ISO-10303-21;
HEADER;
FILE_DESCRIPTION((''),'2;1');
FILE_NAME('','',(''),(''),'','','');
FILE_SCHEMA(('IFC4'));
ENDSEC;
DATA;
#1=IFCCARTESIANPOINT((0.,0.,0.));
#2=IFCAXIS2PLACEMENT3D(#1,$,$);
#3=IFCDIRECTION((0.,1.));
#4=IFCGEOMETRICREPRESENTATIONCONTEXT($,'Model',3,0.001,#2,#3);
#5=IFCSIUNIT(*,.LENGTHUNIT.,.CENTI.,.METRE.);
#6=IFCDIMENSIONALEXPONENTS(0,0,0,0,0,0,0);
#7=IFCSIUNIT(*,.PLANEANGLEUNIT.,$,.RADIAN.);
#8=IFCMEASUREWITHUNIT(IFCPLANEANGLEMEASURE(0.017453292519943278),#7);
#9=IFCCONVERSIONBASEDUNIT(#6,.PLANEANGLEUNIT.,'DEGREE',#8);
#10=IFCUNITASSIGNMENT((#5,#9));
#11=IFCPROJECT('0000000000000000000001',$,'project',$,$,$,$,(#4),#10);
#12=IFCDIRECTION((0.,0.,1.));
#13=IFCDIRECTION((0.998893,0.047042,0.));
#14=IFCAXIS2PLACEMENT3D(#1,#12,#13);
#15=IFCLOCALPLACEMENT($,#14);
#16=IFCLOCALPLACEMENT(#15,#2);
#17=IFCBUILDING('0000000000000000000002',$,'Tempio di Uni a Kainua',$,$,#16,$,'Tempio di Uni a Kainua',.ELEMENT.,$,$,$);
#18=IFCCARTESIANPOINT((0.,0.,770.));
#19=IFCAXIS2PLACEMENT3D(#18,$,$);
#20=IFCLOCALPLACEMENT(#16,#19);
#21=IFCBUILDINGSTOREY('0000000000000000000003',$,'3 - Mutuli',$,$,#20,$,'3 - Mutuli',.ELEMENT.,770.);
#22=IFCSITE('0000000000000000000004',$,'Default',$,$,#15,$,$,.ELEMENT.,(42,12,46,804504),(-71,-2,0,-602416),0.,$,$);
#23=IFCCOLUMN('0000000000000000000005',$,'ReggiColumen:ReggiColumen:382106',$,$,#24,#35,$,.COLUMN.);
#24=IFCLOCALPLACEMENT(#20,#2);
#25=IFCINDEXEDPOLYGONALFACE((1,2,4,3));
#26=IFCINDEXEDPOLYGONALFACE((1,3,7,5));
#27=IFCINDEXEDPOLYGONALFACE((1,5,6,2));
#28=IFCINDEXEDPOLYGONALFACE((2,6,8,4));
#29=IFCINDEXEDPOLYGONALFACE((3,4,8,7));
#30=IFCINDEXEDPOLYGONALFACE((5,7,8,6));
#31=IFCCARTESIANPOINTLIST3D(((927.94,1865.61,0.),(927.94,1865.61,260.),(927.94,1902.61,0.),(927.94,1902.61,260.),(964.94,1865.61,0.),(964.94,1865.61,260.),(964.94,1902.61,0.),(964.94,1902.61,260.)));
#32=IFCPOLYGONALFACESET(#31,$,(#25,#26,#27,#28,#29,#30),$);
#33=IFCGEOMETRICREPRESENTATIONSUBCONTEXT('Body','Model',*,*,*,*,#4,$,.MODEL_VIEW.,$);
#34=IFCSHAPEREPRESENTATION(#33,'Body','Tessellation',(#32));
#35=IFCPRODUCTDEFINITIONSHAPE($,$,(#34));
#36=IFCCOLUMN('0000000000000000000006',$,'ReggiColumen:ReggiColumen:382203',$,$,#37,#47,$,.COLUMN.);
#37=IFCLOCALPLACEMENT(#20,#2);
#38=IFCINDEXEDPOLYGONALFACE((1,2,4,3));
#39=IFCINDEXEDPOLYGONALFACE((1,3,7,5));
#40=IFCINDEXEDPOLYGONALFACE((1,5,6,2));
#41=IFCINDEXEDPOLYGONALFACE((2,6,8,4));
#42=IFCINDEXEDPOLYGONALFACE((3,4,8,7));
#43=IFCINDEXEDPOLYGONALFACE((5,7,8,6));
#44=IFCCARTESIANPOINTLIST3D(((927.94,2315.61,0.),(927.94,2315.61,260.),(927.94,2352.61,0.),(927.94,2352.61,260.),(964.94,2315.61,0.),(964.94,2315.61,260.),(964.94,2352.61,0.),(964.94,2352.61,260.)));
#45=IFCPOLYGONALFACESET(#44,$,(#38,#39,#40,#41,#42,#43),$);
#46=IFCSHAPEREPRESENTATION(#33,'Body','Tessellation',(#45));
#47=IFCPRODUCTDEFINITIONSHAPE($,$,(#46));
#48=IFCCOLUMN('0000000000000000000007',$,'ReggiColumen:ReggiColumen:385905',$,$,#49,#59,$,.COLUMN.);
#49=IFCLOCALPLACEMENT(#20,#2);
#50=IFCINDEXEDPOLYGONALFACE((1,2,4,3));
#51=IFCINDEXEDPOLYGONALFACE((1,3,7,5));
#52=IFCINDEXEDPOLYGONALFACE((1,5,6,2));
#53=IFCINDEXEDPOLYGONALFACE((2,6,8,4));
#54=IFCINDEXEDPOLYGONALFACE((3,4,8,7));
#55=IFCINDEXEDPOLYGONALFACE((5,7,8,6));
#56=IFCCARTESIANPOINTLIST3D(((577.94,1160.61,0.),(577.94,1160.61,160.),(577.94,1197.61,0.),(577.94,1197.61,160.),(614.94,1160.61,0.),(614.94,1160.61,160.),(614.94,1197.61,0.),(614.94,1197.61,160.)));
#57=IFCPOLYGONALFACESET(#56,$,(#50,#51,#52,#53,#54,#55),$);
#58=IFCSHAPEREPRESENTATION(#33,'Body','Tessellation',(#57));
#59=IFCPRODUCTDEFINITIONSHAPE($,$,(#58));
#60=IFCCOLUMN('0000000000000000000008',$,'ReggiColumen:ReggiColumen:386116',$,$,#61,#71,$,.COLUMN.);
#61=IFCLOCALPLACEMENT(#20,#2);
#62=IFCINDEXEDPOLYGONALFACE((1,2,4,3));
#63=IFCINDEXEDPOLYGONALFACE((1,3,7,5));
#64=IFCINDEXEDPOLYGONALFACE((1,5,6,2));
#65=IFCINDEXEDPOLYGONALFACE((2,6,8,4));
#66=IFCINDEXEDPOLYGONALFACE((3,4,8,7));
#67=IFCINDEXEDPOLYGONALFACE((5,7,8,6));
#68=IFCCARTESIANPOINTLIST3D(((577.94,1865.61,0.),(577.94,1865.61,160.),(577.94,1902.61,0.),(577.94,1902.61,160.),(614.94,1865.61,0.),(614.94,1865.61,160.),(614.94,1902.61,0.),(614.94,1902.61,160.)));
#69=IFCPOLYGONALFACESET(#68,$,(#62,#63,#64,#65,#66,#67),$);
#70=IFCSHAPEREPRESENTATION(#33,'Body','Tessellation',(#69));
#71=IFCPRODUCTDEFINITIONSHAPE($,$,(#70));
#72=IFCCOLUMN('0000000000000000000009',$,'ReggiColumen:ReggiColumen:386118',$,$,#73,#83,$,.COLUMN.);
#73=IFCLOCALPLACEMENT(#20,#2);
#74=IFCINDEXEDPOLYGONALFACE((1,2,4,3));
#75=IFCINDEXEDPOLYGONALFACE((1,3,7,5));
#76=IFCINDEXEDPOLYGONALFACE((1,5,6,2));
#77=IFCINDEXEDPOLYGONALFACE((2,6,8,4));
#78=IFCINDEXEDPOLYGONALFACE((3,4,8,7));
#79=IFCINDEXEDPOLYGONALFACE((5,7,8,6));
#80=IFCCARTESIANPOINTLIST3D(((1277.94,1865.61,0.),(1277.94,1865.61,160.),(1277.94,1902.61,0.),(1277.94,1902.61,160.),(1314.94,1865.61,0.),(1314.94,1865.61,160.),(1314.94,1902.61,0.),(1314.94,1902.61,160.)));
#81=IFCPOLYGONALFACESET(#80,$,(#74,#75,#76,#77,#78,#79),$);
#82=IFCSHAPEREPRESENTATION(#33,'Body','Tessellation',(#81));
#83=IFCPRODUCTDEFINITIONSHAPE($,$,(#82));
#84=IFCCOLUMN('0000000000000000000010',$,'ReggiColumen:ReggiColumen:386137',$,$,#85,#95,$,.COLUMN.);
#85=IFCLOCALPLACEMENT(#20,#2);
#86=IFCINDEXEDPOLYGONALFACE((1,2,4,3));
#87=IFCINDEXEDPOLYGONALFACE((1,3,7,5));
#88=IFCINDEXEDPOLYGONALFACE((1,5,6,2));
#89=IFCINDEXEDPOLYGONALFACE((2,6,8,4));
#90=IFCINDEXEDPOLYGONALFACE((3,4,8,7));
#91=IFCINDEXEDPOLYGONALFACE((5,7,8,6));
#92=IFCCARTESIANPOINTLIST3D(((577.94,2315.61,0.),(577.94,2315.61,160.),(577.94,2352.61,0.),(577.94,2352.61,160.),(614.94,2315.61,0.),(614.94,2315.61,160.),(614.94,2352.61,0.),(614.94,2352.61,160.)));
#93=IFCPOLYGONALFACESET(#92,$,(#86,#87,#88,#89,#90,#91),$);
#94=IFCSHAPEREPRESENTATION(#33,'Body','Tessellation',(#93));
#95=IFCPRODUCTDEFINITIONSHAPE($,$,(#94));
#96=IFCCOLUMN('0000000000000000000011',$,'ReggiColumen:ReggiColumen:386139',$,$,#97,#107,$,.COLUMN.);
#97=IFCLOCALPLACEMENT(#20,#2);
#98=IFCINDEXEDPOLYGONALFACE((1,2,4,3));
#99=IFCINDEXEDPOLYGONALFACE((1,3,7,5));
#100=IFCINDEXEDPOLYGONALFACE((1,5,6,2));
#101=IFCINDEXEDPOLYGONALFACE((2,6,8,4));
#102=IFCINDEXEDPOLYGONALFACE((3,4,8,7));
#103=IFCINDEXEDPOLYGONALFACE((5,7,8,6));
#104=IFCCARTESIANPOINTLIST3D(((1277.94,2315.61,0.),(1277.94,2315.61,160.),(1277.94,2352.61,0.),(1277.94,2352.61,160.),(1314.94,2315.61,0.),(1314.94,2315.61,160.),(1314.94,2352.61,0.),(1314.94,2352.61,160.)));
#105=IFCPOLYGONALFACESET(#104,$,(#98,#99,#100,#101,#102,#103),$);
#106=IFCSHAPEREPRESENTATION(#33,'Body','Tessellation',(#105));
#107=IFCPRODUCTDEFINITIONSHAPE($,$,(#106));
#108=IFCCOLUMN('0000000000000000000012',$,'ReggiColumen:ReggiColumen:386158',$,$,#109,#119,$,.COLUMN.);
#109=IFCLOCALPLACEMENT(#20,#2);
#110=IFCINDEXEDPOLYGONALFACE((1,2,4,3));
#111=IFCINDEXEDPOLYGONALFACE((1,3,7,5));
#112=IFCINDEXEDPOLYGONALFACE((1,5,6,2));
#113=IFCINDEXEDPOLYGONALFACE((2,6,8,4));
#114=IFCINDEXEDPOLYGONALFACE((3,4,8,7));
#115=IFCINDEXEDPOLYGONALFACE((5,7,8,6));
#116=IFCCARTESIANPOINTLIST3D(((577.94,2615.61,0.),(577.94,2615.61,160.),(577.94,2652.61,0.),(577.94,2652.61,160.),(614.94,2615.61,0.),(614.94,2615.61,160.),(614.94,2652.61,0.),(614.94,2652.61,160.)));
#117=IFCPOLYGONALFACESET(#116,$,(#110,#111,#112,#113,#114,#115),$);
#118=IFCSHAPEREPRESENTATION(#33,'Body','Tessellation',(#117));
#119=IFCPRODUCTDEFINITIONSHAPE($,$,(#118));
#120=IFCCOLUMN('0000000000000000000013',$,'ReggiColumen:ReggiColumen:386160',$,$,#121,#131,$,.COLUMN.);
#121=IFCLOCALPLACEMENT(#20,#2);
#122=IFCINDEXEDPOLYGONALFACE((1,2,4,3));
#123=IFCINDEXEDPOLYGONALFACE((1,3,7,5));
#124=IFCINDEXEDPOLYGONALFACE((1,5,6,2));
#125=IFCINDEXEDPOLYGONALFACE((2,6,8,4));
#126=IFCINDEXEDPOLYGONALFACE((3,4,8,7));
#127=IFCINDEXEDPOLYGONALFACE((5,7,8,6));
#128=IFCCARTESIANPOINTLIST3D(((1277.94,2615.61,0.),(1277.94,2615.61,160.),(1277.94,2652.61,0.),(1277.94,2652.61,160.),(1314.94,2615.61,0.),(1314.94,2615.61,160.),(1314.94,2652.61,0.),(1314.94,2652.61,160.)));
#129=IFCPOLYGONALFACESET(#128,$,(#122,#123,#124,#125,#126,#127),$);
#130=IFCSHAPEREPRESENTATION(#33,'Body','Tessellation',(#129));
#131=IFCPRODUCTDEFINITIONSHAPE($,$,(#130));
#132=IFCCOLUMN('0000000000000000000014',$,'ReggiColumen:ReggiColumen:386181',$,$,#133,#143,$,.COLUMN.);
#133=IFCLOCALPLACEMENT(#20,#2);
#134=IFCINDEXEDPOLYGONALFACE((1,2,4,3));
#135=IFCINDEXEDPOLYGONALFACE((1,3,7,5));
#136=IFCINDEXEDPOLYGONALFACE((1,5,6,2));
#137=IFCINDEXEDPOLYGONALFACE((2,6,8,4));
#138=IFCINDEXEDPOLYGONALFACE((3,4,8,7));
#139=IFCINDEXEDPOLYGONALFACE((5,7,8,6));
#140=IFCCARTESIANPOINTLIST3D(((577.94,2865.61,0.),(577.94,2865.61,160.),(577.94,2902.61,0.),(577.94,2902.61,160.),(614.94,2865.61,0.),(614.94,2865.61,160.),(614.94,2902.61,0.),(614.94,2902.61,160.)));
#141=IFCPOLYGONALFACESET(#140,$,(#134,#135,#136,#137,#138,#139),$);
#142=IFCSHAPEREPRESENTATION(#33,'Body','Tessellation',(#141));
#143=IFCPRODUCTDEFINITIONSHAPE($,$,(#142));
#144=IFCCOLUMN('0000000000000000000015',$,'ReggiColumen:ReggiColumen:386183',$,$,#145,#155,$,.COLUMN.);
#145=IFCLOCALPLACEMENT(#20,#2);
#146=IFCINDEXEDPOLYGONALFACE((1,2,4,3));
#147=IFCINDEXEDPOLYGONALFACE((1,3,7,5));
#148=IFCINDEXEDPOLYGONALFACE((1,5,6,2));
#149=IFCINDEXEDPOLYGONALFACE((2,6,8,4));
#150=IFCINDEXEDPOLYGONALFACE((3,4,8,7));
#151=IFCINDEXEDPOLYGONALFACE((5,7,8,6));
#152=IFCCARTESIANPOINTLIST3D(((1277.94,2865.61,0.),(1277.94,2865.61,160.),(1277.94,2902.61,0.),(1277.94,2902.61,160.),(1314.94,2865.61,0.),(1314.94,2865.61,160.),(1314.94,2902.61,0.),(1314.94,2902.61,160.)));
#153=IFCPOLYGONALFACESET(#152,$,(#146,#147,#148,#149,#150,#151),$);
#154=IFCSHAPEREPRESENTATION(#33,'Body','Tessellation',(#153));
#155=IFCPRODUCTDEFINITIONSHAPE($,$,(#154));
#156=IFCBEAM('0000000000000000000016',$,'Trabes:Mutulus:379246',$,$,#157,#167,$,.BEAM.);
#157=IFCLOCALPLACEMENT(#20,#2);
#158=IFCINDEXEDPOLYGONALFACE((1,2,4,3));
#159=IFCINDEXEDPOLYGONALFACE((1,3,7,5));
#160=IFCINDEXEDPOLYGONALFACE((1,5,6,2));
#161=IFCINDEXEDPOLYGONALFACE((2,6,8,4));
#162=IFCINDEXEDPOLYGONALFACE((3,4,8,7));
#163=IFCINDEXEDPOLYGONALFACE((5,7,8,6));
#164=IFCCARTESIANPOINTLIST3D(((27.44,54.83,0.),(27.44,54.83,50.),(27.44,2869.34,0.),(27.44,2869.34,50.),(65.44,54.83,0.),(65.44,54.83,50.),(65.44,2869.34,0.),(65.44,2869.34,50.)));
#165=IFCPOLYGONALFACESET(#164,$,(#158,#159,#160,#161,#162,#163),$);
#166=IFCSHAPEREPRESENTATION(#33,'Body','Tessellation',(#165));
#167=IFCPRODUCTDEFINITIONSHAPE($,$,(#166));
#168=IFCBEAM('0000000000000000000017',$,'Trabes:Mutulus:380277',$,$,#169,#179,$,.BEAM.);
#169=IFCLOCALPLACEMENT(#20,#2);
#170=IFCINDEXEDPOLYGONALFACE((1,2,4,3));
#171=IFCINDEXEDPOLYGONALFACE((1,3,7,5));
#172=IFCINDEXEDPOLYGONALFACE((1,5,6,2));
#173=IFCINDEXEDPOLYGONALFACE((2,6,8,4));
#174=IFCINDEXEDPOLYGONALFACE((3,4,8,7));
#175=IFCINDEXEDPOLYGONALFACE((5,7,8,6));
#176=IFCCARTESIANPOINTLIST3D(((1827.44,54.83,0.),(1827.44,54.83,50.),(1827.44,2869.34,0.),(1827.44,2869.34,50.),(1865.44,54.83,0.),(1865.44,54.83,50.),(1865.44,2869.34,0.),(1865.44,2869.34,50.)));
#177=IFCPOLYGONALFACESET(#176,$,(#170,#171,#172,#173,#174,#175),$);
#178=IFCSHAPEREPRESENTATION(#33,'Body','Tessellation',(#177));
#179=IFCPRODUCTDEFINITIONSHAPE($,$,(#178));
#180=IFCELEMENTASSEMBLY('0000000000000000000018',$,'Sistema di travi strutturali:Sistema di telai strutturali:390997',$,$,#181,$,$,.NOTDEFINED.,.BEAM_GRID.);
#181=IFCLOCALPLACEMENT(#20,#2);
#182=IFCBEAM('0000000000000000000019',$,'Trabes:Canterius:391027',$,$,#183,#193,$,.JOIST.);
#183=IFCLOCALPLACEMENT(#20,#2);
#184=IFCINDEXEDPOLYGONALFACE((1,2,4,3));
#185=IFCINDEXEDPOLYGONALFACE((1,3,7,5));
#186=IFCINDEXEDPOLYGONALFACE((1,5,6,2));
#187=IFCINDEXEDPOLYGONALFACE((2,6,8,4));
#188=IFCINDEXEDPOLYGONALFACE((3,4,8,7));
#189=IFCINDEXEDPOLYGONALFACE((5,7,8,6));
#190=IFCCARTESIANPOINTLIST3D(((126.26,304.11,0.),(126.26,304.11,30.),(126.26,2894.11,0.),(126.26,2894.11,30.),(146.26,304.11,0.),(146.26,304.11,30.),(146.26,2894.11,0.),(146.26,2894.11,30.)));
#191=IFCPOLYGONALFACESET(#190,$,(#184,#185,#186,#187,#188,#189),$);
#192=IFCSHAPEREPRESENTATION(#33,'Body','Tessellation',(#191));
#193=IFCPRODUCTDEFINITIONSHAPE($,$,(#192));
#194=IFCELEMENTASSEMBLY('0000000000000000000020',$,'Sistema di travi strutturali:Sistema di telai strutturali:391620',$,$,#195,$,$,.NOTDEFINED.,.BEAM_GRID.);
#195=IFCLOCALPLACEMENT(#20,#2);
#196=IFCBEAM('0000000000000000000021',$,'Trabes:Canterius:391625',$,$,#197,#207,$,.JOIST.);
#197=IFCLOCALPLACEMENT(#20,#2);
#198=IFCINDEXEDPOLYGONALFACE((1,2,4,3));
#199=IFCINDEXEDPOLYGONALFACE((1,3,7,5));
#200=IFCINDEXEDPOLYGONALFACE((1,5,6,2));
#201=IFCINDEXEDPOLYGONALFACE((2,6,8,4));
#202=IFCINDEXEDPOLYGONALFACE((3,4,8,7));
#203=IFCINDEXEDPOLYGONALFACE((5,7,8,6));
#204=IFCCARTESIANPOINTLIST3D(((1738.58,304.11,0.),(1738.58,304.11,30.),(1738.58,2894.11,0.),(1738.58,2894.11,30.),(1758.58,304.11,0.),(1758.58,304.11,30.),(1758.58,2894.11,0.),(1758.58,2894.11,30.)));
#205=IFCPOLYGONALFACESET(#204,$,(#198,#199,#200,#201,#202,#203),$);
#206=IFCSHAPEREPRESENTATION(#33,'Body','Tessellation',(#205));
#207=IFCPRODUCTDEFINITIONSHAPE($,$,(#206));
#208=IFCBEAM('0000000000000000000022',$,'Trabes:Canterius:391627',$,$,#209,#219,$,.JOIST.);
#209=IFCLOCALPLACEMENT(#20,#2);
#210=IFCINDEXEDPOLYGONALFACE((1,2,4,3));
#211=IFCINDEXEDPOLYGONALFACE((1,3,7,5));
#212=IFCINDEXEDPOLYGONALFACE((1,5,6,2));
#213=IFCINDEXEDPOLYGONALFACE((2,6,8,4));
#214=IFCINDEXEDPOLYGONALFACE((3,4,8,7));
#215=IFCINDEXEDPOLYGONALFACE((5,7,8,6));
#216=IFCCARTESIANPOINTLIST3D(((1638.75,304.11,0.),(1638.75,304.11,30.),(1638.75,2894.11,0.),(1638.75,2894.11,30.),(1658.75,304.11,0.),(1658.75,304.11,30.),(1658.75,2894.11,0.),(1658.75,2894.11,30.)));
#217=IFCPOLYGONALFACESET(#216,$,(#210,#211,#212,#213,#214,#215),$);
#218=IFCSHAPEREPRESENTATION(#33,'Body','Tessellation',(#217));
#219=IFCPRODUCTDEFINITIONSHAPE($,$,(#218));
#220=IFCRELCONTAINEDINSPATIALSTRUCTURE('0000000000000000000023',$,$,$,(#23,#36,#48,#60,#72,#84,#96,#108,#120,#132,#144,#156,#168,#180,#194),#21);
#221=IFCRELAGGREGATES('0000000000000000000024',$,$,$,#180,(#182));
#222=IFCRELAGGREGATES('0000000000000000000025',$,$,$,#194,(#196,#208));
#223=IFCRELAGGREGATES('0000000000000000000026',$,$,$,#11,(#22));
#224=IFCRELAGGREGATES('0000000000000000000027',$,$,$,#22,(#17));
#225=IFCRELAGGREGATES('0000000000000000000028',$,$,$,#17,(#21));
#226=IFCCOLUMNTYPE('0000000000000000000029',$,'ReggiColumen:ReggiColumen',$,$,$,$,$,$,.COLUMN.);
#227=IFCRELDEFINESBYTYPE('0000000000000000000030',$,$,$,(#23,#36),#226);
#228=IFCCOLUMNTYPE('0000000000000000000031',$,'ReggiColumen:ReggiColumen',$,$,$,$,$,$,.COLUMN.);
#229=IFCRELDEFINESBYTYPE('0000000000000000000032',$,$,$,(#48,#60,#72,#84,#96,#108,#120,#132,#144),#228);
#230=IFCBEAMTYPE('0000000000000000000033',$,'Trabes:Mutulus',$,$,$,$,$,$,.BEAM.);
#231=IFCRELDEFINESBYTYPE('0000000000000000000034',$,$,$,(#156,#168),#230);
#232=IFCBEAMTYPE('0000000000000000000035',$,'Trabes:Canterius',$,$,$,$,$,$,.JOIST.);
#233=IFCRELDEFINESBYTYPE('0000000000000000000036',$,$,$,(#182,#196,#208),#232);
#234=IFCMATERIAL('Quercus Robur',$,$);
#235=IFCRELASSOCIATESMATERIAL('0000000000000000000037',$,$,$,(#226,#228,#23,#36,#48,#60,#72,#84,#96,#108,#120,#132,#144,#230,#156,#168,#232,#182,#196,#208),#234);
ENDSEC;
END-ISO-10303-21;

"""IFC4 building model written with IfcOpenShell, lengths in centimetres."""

from ifc_helpers import new_model, entity, si_unit, converted_unit, direction, frame, frame_2d, origin, origin_2d_with_axis, place, context, subcontext, project, spatial, rectangle, extrude, source, transform, mapped, material, material_profile, profile_set, profile_usage, type_object, type_shapes, element, aggregate, save


model = new_model("IFC4")

# Units and contexts
model_context = context("Model", 3, precision=0.001, world=origin(), true_north=direction((0.0, 1.0)))
body_context = subcontext(model_context, "Body", "Model", "MODEL_VIEW")
ifc_project = project(units=[si_unit("LENGTHUNIT", "METRE", prefix="CENTI"), converted_unit("PLANEANGLEUNIT", "DEGREE", entity("IfcPlaneAngleMeasure", 0.017453292519943278), si_unit("PLANEANGLEUNIT", "RADIAN"), dimensions=[0, 0, 0, 0, 0, 0, 0])], contexts=[model_context])

# Site, building, storey
site_placement = place(None, frame((0.0, 0.0, 0.0), z_axis=(0.0, 0.0, 1.0), x_axis=(0.998893, 0.047042, 0.0)))
site = spatial("IfcSite", under=ifc_project, at=site_placement, Name="Default", CompositionType="ELEMENT", RefLatitude=(42, 12, 46, 804504), RefLongitude=(-71, -2, 0, -602416), RefElevation=0.0)
building_placement = place(site_placement, origin())
building = spatial("IfcBuilding", under=site, at=building_placement, Name="Tempio di Uni a Kainua", LongName="Tempio di Uni a Kainua", CompositionType="ELEMENT")
storey_placement = place(building_placement, frame((0.0, 0.0, 770.0)))
storey = spatial("IfcBuildingStorey", under=building, at=storey_placement, Name="3 - Mutuli", LongName="3 - Mutuli", CompositionType="ELEMENT", Elevation=770.0)

# Columns
ifc_material = material(Name="Quercus Robur")
ifc_material_profile_1 = material_profile(ifc_material, rectangle(XDim=37.0, YDim=37.0, at=frame_2d((0.0, 0.0), x_axis=(1.0, 0.0))), Name="ReggiColumen")
ifc_profile_set_1 = profile_set([ifc_material_profile_1], Name="ReggiColumen")
ifc_profile_usage_1 = profile_usage(ifc_profile_set_1)
column_type_1 = type_object("IfcColumnType", Name="ReggiColumen:ReggiColumen", PredefinedType="COLUMN", material=ifc_profile_set_1)
shared_shape_1 = source(origin(), body_context, "Body", "SweptSolid", [
    extrude(rectangle(XDim=37.0, YDim=37.0, at=origin_2d_with_axis()), frame((0.0, 0.0, 770.0), z_axis=(0.0, 0.0, 1.0), x_axis=(-1.0, 0.0, 0.0)), (0.0, 0.0, 1.0), 260.0),
])
type_shapes(column_type_1, [shared_shape_1])
for number, where, name in (
    (1, (946.44, 1884.11, -770.0), "ReggiColumen:ReggiColumen:382106"),
    (2, (946.44, 2334.11, -770.0), "ReggiColumen:ReggiColumen:382203"),
):
    element("IfcColumn", number, at=place(storey_placement, frame(where)), inside=storey, type_object=column_type_1, material=ifc_profile_usage_1, Name=name, PredefinedType="COLUMN", context=body_context, shape_type="MappedRepresentation", body=[
        mapped(shared_shape_1, transform((0.0, 0.0, 0.0), scale=1.0)),
    ])
column_type_2 = type_object("IfcColumnType", Name="ReggiColumen:ReggiColumen", PredefinedType="COLUMN", material=ifc_profile_set_1)
shared_shape_2 = source(origin(), body_context, "Body", "SweptSolid", [
    extrude(rectangle(XDim=37.0, YDim=37.0, at=origin_2d_with_axis()), frame((0.0, 0.0, 770.0), z_axis=(0.0, 0.0, 1.0), x_axis=(-1.0, 0.0, 0.0)), (0.0, 0.0, 1.0), 160.0),
])
type_shapes(column_type_2, [shared_shape_2])
for number, where, name in (
    (3, (596.44, 1179.11, -770.0), "ReggiColumen:ReggiColumen:385905"),
    (4, (596.44, 1884.11, -770.0), "ReggiColumen:ReggiColumen:386116"),
    (5, (1296.44, 1884.11, -770.0), "ReggiColumen:ReggiColumen:386118"),
    (6, (596.44, 2334.11, -770.0), "ReggiColumen:ReggiColumen:386137"),
    (7, (1296.44, 2334.11, -770.0), "ReggiColumen:ReggiColumen:386139"),
    (8, (596.44, 2634.11, -770.0), "ReggiColumen:ReggiColumen:386158"),
    (9, (1296.44, 2634.11, -770.0), "ReggiColumen:ReggiColumen:386160"),
    (10, (596.44, 2884.11, -770.0), "ReggiColumen:ReggiColumen:386181"),
    (11, (1296.44, 2884.11, -770.0), "ReggiColumen:ReggiColumen:386183"),
):
    element("IfcColumn", number, at=place(storey_placement, frame(where)), inside=storey, type_object=column_type_2, material=ifc_profile_usage_1, Name=name, PredefinedType="COLUMN", context=body_context, shape_type="MappedRepresentation", body=[
        mapped(shared_shape_2, transform((0.0, 0.0, 0.0), scale=1.0)),
    ])

# Beams
ifc_material_profile_2 = material_profile(ifc_material, rectangle(XDim=2814.5, YDim=38.0, at=origin_2d_with_axis()), Name="Mutulus")
ifc_profile_set_2 = profile_set([ifc_material_profile_2], Name="Mutulus")
ifc_profile_usage_2 = profile_usage(ifc_profile_set_2, cardinal=8)
beam_type_1 = type_object("IfcBeamType", Name="Trabes:Mutulus", PredefinedType="BEAM", material=ifc_profile_set_2)
shared_shape_3 = source(origin(), body_context, "Body", "SweptSolid", [
    extrude(rectangle(XDim=2814.5, YDim=38.0, at=origin_2d_with_axis()), frame((227.77, 0.0, -25.0)), (0.0, 0.0, 1.0), 50.0),
])
type_shapes(beam_type_1, [shared_shape_3])
for number, where, z_axis, x_axis, name in (
    (12, (46.44, 1689.86, 25.0), (0.0, 0.0, 1.0), (0.0, -1.0, 0.0), "Trabes:Mutulus:379246"),
    (13, (1846.44, 1689.86, 25.0), (0.0, 0.0, 1.0), (0.0, -1.0, 0.0), "Trabes:Mutulus:380277"),
):
    element("IfcBeam", number, at=place(storey_placement, frame(where, z_axis=z_axis, x_axis=x_axis)), inside=storey, type_object=beam_type_1, material=ifc_profile_usage_2, Name=name, PredefinedType="BEAM", context=body_context, shape_type="MappedRepresentation", body=[
        mapped(shared_shape_3, transform((0.0, 0.0, 0.0), scale=1.0)),
    ])

# Element assembly, beam
assembly_1_placement = place(storey_placement, origin())
assembly_1 = element("IfcElementAssembly", 14, at=assembly_1_placement, inside=storey, Name="Sistema di travi strutturali:Sistema di telai strutturali:390997", AssemblyPlace="NOTDEFINED", PredefinedType="BEAM_GRID")
ifc_material_profile_3 = material_profile(ifc_material, rectangle(XDim=2590.0, YDim=20.0, at=origin_2d_with_axis()), Name="Canterius")
ifc_profile_set_3 = profile_set([ifc_material_profile_3], Name="Canterius")
ifc_profile_usage_3 = profile_usage(ifc_profile_set_3, cardinal=3)
beam_type_2 = type_object("IfcBeamType", Name="Trabes:Canterius", PredefinedType="JOIST", material=ifc_profile_set_3)
shared_shape_4 = source(origin(), body_context, "Body", "SweptSolid", [
    extrude(rectangle(XDim=2590.0, YDim=20.0, at=origin_2d_with_axis()), frame((-80.0, 0.0, -15.0)), (0.0, 0.0, 1.0), 30.0),
])
type_shapes(beam_type_2, [shared_shape_4])
beam_1_placement = place(assembly_1_placement, frame((136.26, 1679.11, 15.0), z_axis=(0.0, 0.0, 1.0), x_axis=(0.0, 1.0, 0.0)))
beam_1 = element("IfcBeam", 15, at=beam_1_placement, type_object=beam_type_2, material=ifc_profile_usage_3, Name="Trabes:Canterius:391027", PredefinedType="JOIST", context=body_context, shape_type="MappedRepresentation", body=[
    mapped(shared_shape_4, transform((0.0, 0.0, 0.0), scale=1.0)),
])
aggregate(assembly_1, [beam_1])

# Element assembly, beams
assembly_2_placement = place(storey_placement, origin())
assembly_2 = element("IfcElementAssembly", 16, at=assembly_2_placement, inside=storey, Name="Sistema di travi strutturali:Sistema di telai strutturali:391620", AssemblyPlace="NOTDEFINED", PredefinedType="BEAM_GRID")
beam_2_placement = place(assembly_2_placement, frame((1748.58, 1679.11, 15.0), z_axis=(0.0, 0.0, 1.0), x_axis=(0.0, 1.0, 0.0)))
beam_2 = element("IfcBeam", 17, at=beam_2_placement, type_object=beam_type_2, material=ifc_profile_usage_3, Name="Trabes:Canterius:391625", PredefinedType="JOIST", context=body_context, shape_type="MappedRepresentation", body=[
    mapped(shared_shape_4, transform((0.0, 0.0, 0.0), scale=1.0)),
])
beam_3_placement = place(assembly_2_placement, frame((1648.75, 1679.11, 15.0), z_axis=(0.0, 0.0, 1.0), x_axis=(0.0, 1.0, 0.0)))
beam_3 = element("IfcBeam", 18, at=beam_3_placement, type_object=beam_type_2, material=ifc_profile_usage_3, Name="Trabes:Canterius:391627", PredefinedType="JOIST", context=body_context, shape_type="MappedRepresentation", body=[
    mapped(shared_shape_4, transform((0.0, 0.0, 0.0), scale=1.0)),
])
aggregate(assembly_2, [beam_2, beam_3])

save(model, "model.ifc")
